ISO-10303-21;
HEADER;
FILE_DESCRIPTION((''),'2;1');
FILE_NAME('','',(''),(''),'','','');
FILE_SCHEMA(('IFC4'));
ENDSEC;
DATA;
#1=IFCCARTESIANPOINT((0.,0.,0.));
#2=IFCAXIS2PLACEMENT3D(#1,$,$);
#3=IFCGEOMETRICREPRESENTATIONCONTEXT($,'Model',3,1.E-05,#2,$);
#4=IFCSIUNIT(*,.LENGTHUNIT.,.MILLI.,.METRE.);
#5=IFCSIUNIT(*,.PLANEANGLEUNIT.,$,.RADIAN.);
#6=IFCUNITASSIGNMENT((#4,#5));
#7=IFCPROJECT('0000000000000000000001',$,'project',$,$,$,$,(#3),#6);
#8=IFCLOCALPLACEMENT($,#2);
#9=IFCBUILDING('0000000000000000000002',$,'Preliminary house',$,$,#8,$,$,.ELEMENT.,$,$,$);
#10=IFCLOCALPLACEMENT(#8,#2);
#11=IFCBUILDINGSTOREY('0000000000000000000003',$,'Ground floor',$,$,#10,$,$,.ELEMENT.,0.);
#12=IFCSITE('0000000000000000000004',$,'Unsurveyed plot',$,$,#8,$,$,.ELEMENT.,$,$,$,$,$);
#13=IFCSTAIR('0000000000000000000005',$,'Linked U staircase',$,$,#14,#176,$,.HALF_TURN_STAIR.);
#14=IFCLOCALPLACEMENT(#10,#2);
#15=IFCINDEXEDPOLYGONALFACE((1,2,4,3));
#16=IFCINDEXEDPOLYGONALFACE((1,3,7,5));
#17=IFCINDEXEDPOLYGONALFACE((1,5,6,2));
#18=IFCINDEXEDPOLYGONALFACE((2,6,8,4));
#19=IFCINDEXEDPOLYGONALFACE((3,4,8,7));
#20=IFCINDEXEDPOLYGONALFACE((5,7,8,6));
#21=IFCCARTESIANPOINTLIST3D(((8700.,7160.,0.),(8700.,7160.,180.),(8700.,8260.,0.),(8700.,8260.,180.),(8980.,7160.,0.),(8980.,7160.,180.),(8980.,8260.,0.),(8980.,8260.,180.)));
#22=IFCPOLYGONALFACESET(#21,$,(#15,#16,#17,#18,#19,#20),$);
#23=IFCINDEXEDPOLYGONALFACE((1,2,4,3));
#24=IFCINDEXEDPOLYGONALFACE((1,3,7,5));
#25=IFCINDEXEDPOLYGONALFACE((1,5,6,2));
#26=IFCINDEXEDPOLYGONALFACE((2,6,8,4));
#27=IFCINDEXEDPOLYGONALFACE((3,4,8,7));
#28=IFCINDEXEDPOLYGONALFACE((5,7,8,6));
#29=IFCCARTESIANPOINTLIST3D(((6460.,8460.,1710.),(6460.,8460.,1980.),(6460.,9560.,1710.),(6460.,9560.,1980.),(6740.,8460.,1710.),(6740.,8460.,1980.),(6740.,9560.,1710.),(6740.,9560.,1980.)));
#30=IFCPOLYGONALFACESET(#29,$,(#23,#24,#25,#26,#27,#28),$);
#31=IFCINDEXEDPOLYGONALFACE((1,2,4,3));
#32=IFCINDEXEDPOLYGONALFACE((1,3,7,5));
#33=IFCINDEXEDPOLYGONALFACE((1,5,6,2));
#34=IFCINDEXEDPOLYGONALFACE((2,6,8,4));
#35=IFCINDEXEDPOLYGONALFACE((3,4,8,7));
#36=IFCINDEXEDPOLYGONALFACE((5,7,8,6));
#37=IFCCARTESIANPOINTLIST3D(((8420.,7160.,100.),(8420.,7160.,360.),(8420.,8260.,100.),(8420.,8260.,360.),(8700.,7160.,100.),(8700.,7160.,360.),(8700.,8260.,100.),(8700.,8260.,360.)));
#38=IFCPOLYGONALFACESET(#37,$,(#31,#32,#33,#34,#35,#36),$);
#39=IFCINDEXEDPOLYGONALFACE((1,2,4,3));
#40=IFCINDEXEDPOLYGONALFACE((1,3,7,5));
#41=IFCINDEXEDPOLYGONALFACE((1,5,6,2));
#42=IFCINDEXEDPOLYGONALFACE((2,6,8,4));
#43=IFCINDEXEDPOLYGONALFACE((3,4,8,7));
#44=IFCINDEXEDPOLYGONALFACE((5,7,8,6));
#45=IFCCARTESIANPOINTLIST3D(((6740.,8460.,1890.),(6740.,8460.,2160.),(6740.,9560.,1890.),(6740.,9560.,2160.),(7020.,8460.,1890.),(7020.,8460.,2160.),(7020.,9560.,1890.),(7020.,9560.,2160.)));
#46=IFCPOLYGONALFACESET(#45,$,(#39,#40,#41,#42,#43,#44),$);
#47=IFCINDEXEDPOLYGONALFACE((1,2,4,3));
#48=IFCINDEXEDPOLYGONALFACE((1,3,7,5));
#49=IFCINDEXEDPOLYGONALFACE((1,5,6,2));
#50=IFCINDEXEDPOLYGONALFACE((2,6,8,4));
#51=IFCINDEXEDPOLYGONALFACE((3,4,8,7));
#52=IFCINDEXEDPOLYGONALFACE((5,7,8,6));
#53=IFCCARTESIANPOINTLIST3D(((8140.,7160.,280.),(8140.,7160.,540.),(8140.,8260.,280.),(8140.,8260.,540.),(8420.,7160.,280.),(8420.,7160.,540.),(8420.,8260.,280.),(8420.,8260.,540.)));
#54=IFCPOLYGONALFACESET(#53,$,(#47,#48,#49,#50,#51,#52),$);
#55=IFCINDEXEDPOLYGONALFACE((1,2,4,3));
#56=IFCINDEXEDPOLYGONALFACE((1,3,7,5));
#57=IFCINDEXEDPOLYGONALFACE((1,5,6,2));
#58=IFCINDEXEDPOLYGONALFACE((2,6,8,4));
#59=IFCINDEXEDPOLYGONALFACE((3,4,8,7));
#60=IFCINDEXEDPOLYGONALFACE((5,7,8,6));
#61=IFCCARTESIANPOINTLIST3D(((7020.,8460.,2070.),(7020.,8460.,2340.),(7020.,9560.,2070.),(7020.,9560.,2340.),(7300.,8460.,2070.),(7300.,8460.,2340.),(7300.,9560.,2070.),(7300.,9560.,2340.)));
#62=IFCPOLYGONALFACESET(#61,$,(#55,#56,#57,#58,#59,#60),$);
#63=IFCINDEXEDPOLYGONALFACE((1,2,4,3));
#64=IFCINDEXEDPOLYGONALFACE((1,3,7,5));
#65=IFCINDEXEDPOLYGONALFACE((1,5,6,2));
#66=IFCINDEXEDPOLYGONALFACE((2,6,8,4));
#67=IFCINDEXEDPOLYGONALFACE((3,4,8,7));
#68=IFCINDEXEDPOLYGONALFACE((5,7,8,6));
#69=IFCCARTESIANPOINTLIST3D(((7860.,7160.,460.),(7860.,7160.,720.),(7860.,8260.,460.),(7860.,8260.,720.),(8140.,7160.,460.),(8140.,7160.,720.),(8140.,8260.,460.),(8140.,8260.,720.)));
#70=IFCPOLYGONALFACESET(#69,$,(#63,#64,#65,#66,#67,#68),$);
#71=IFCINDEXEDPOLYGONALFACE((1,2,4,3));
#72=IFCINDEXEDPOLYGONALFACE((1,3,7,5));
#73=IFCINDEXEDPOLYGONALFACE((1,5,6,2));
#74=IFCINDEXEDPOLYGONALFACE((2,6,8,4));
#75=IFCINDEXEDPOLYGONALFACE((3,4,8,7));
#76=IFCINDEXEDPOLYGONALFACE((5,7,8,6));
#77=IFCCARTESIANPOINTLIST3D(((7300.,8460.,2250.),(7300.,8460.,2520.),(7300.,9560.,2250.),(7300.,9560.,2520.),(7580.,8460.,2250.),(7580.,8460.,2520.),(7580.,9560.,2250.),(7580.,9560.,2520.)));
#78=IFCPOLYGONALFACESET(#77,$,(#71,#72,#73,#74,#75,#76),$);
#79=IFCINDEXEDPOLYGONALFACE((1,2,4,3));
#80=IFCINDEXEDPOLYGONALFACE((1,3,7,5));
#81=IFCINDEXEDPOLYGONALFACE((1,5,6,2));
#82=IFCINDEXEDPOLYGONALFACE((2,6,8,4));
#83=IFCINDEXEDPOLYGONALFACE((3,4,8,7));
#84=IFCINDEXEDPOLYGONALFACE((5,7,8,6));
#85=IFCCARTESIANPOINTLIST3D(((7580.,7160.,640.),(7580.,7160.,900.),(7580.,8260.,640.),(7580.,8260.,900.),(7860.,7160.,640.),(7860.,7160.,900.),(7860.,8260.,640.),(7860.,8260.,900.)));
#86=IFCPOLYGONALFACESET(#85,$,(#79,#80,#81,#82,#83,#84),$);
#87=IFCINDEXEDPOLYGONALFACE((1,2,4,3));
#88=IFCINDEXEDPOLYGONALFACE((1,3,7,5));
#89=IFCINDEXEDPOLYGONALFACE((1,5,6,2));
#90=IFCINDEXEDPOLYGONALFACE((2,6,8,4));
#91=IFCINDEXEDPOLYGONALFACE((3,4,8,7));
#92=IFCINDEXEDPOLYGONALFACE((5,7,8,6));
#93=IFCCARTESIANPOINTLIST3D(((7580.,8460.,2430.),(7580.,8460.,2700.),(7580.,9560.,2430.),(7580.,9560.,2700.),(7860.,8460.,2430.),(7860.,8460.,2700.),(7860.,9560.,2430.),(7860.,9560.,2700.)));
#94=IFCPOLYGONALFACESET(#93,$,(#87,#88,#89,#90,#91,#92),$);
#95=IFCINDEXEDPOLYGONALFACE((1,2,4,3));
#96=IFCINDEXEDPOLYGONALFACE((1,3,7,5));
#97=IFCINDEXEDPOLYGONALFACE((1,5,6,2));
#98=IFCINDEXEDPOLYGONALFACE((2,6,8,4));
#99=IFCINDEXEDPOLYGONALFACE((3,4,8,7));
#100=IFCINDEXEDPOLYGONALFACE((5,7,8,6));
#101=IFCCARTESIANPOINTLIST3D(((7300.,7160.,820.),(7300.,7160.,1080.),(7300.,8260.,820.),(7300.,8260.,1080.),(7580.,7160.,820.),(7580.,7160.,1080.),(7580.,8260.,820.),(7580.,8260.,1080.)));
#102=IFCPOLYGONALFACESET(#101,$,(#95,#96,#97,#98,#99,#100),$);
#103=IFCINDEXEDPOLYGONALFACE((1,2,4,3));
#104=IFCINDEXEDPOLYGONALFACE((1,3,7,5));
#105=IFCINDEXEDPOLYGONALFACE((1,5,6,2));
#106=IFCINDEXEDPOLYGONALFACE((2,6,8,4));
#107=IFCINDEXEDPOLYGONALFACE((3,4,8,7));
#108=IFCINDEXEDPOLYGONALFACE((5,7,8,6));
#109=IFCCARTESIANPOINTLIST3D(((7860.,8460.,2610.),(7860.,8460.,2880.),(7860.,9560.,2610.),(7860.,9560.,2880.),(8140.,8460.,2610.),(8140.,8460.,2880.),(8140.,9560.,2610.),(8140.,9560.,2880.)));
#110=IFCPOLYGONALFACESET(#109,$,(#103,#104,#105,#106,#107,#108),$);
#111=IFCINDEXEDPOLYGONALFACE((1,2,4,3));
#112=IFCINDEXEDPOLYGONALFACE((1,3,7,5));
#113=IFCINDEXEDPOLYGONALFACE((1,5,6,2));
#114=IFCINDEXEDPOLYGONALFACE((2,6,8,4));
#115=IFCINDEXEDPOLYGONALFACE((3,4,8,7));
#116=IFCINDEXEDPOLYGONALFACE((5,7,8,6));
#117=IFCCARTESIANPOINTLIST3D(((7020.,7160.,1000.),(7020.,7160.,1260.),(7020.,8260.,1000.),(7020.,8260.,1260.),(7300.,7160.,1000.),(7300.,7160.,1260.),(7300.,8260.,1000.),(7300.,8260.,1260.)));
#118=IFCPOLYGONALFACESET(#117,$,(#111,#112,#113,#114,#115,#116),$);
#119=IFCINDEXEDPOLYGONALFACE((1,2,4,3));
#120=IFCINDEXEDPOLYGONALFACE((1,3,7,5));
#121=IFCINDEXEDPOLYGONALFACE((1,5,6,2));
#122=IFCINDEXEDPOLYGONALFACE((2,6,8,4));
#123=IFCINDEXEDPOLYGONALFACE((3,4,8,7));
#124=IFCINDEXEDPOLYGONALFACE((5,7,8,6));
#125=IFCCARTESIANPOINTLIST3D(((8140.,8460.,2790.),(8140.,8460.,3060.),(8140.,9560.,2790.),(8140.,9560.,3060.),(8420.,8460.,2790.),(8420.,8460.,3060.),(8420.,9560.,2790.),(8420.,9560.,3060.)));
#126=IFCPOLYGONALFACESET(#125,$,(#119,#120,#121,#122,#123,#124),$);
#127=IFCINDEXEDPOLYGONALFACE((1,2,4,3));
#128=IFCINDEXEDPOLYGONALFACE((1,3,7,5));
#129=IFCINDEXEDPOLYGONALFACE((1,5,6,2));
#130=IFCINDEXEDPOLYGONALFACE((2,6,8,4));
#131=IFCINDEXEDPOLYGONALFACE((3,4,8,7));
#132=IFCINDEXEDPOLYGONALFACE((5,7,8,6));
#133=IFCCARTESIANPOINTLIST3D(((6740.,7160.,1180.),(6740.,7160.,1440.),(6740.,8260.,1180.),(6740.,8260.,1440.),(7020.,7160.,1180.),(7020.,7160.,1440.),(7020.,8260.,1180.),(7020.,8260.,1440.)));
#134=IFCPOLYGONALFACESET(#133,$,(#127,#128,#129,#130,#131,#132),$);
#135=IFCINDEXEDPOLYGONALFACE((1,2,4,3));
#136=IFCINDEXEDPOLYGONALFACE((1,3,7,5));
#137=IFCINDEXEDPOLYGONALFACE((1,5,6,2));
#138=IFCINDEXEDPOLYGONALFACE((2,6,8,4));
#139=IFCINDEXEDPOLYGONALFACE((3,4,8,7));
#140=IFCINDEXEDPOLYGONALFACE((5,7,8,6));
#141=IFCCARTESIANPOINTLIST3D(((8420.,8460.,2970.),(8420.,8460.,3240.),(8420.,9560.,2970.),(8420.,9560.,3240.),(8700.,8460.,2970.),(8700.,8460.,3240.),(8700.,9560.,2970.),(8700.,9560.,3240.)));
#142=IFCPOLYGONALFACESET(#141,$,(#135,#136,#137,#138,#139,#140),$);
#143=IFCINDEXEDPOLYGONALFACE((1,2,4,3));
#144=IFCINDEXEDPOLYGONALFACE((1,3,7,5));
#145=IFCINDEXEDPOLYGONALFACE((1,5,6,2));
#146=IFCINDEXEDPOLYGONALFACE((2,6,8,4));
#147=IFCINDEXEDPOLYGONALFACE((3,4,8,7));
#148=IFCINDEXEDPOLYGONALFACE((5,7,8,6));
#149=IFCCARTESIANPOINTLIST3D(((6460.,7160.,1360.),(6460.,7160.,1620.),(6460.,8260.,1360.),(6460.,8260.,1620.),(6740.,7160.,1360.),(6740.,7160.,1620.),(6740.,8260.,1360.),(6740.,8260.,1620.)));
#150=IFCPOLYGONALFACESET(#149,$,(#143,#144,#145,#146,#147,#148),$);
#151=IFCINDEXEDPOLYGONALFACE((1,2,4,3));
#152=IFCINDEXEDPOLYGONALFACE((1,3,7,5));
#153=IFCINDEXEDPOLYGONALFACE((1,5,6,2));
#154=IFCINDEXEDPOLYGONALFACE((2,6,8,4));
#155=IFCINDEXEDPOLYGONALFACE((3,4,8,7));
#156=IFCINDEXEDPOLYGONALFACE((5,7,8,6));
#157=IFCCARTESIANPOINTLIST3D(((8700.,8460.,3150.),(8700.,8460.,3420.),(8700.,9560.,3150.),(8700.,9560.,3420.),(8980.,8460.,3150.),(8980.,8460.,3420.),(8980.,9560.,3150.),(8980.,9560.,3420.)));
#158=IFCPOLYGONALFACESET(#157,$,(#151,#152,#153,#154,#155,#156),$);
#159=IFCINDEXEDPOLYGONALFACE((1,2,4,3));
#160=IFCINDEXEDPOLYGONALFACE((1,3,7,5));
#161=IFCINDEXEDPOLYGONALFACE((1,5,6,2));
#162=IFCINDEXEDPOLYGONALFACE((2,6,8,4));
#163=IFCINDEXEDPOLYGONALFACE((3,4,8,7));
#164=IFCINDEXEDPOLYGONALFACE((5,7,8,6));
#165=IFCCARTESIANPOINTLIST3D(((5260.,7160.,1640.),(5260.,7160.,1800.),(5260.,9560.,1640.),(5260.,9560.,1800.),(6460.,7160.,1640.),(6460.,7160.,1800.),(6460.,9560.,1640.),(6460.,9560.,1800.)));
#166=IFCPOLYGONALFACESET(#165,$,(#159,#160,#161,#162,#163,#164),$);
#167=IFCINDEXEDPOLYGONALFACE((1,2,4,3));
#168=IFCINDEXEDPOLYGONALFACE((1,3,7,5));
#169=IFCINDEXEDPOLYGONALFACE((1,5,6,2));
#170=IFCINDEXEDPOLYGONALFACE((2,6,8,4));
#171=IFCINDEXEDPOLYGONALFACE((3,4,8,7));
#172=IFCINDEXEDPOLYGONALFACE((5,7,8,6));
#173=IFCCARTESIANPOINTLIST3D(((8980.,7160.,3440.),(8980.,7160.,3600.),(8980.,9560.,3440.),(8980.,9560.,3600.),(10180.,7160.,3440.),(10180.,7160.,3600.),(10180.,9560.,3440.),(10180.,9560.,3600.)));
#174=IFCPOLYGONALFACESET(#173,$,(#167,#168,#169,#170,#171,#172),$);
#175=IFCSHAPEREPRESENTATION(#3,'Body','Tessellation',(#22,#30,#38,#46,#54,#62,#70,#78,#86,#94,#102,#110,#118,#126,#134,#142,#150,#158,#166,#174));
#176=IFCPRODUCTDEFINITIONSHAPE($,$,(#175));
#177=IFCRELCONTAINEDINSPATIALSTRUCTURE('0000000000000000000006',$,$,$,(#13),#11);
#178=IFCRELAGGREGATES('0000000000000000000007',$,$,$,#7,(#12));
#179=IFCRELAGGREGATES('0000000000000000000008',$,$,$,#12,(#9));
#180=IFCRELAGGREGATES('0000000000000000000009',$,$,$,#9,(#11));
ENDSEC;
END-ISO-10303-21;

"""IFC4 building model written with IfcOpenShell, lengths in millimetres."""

from ifc_helpers import new_model, si_unit, frame, origin, place, context, project, spatial, polyline, outline, extrude, element, save


model = new_model("IFC4")

# Units and contexts
model_context = context("Model", 3, precision=1e-05, world=origin())
ifc_project = project(units=[si_unit("LENGTHUNIT", "METRE", prefix="MILLI"), si_unit("PLANEANGLEUNIT", "RADIAN")], contexts=[model_context])

# Site, building, storey
placement_1 = place(None, origin())
site = spatial("IfcSite", under=ifc_project, at=placement_1, Name="Unsurveyed plot", CompositionType="ELEMENT")
building = spatial("IfcBuilding", under=site, at=placement_1, Name="Preliminary house", CompositionType="ELEMENT")
placement_2 = place(placement_1, origin())
storey = spatial("IfcBuildingStorey", under=building, at=placement_2, Name="Ground floor", CompositionType="ELEMENT", Elevation=0.0)

# Stair
element("IfcStair", 1, at=placement_2, inside=storey, Name="Linked U staircase", PredefinedType="HALF_TURN_STAIR", context=model_context, shape_type="SweptSolid", body=[
    extrude(outline(polyline([(8980.0, 8260.0), (8700.0, 8260.0), (8700.0, 7160.0), (8980.0, 7160.0), (8980.0, 8260.0)])), origin(), (0.0, 0.0, 1.0), 180.0),
    extrude(outline(polyline([(6740.0, 9560.0), (6460.0, 9560.0), (6460.0, 8460.0), (6740.0, 8460.0), (6740.0, 9560.0)])), frame((0.0, 0.0, 1710.0)), (0.0, 0.0, 1.0), 270.0),
    extrude(outline(polyline([(8700.0, 8260.0), (8420.0, 8260.0), (8420.0, 7160.0), (8700.0, 7160.0), (8700.0, 8260.0)])), frame((0.0, 0.0, 100.0)), (0.0, 0.0, 1.0), 260.0),
    extrude(outline(polyline([(7020.0, 9560.0), (6740.0, 9560.0), (6740.0, 8460.0), (7020.0, 8460.0), (7020.0, 9560.0)])), frame((0.0, 0.0, 1890.0)), (0.0, 0.0, 1.0), 270.0),
    extrude(outline(polyline([(8420.0, 8260.0), (8140.0, 8260.0), (8140.0, 7160.0), (8420.0, 7160.0), (8420.0, 8260.0)])), frame((0.0, 0.0, 280.0)), (0.0, 0.0, 1.0), 260.0),
    extrude(outline(polyline([(7300.0, 9560.0), (7020.0, 9560.0), (7020.0, 8460.0), (7300.0, 8460.0), (7300.0, 9560.0)])), frame((0.0, 0.0, 2070.0)), (0.0, 0.0, 1.0), 270.0),
    extrude(outline(polyline([(8140.0, 8260.0), (7860.0, 8260.0), (7860.0, 7160.0), (8140.0, 7160.0), (8140.0, 8260.0)])), frame((0.0, 0.0, 460.0)), (0.0, 0.0, 1.0), 260.0),
    extrude(outline(polyline([(7580.0, 9560.0), (7300.0, 9560.0), (7300.0, 8460.0), (7580.0, 8460.0), (7580.0, 9560.0)])), frame((0.0, 0.0, 2250.0)), (0.0, 0.0, 1.0), 270.0),
    extrude(outline(polyline([(7860.0, 8260.0), (7580.0, 8260.0), (7580.0, 7160.0), (7860.0, 7160.0), (7860.0, 8260.0)])), frame((0.0, 0.0, 640.0)), (0.0, 0.0, 1.0), 260.0),
    extrude(outline(polyline([(7860.0, 9560.0), (7580.0, 9560.0), (7580.0, 8460.0), (7860.0, 8460.0), (7860.0, 9560.0)])), frame((0.0, 0.0, 2430.0)), (0.0, 0.0, 1.0), 270.0),
    extrude(outline(polyline([(7580.0, 8260.0), (7300.0, 8260.0), (7300.0, 7160.0), (7580.0, 7160.0), (7580.0, 8260.0)])), frame((0.0, 0.0, 820.0)), (0.0, 0.0, 1.0), 260.0),
    extrude(outline(polyline([(8140.0, 9560.0), (7860.0, 9560.0), (7860.0, 8460.0), (8140.0, 8460.0), (8140.0, 9560.0)])), frame((0.0, 0.0, 2610.0)), (0.0, 0.0, 1.0), 270.0),
    extrude(outline(polyline([(7300.0, 8260.0), (7020.0, 8260.0), (7020.0, 7160.0), (7300.0, 7160.0), (7300.0, 8260.0)])), frame((0.0, 0.0, 1000.0)), (0.0, 0.0, 1.0), 260.0),
    extrude(outline(polyline([(8420.0, 9560.0), (8140.0, 9560.0), (8140.0, 8460.0), (8420.0, 8460.0), (8420.0, 9560.0)])), frame((0.0, 0.0, 2790.0)), (0.0, 0.0, 1.0), 270.0),
    extrude(outline(polyline([(7020.0, 8260.0), (6740.0, 8260.0), (6740.0, 7160.0), (7020.0, 7160.0), (7020.0, 8260.0)])), frame((0.0, 0.0, 1180.0)), (0.0, 0.0, 1.0), 260.0),
    extrude(outline(polyline([(8700.0, 9560.0), (8420.0, 9560.0), (8420.0, 8460.0), (8700.0, 8460.0), (8700.0, 9560.0)])), frame((0.0, 0.0, 2970.0)), (0.0, 0.0, 1.0), 270.0),
    extrude(outline(polyline([(6740.0, 8260.0), (6460.0, 8260.0), (6460.0, 7160.0), (6740.0, 7160.0), (6740.0, 8260.0)])), frame((0.0, 0.0, 1360.0)), (0.0, 0.0, 1.0), 260.0),
    extrude(outline(polyline([(8980.0, 9560.0), (8700.0, 9560.0), (8700.0, 8460.0), (8980.0, 8460.0), (8980.0, 9560.0)])), frame((0.0, 0.0, 3150.0)), (0.0, 0.0, 1.0), 270.0),
    extrude(outline(polyline([(6460.0, 9560.0), (5260.0, 9560.0), (5260.0, 7160.0), (6460.0, 7160.0), (6460.0, 9560.0)])), frame((0.0, 0.0, 1640.0)), (0.0, 0.0, 1.0), 160.0),
    extrude(outline(polyline([(10180.0, 9560.0), (8980.0, 9560.0), (8980.0, 7160.0), (10180.0, 7160.0), (10180.0, 9560.0)])), frame((0.0, 0.0, 3440.0)), (0.0, 0.0, 1.0), 160.0),
])

save(model, "model.ifc")
